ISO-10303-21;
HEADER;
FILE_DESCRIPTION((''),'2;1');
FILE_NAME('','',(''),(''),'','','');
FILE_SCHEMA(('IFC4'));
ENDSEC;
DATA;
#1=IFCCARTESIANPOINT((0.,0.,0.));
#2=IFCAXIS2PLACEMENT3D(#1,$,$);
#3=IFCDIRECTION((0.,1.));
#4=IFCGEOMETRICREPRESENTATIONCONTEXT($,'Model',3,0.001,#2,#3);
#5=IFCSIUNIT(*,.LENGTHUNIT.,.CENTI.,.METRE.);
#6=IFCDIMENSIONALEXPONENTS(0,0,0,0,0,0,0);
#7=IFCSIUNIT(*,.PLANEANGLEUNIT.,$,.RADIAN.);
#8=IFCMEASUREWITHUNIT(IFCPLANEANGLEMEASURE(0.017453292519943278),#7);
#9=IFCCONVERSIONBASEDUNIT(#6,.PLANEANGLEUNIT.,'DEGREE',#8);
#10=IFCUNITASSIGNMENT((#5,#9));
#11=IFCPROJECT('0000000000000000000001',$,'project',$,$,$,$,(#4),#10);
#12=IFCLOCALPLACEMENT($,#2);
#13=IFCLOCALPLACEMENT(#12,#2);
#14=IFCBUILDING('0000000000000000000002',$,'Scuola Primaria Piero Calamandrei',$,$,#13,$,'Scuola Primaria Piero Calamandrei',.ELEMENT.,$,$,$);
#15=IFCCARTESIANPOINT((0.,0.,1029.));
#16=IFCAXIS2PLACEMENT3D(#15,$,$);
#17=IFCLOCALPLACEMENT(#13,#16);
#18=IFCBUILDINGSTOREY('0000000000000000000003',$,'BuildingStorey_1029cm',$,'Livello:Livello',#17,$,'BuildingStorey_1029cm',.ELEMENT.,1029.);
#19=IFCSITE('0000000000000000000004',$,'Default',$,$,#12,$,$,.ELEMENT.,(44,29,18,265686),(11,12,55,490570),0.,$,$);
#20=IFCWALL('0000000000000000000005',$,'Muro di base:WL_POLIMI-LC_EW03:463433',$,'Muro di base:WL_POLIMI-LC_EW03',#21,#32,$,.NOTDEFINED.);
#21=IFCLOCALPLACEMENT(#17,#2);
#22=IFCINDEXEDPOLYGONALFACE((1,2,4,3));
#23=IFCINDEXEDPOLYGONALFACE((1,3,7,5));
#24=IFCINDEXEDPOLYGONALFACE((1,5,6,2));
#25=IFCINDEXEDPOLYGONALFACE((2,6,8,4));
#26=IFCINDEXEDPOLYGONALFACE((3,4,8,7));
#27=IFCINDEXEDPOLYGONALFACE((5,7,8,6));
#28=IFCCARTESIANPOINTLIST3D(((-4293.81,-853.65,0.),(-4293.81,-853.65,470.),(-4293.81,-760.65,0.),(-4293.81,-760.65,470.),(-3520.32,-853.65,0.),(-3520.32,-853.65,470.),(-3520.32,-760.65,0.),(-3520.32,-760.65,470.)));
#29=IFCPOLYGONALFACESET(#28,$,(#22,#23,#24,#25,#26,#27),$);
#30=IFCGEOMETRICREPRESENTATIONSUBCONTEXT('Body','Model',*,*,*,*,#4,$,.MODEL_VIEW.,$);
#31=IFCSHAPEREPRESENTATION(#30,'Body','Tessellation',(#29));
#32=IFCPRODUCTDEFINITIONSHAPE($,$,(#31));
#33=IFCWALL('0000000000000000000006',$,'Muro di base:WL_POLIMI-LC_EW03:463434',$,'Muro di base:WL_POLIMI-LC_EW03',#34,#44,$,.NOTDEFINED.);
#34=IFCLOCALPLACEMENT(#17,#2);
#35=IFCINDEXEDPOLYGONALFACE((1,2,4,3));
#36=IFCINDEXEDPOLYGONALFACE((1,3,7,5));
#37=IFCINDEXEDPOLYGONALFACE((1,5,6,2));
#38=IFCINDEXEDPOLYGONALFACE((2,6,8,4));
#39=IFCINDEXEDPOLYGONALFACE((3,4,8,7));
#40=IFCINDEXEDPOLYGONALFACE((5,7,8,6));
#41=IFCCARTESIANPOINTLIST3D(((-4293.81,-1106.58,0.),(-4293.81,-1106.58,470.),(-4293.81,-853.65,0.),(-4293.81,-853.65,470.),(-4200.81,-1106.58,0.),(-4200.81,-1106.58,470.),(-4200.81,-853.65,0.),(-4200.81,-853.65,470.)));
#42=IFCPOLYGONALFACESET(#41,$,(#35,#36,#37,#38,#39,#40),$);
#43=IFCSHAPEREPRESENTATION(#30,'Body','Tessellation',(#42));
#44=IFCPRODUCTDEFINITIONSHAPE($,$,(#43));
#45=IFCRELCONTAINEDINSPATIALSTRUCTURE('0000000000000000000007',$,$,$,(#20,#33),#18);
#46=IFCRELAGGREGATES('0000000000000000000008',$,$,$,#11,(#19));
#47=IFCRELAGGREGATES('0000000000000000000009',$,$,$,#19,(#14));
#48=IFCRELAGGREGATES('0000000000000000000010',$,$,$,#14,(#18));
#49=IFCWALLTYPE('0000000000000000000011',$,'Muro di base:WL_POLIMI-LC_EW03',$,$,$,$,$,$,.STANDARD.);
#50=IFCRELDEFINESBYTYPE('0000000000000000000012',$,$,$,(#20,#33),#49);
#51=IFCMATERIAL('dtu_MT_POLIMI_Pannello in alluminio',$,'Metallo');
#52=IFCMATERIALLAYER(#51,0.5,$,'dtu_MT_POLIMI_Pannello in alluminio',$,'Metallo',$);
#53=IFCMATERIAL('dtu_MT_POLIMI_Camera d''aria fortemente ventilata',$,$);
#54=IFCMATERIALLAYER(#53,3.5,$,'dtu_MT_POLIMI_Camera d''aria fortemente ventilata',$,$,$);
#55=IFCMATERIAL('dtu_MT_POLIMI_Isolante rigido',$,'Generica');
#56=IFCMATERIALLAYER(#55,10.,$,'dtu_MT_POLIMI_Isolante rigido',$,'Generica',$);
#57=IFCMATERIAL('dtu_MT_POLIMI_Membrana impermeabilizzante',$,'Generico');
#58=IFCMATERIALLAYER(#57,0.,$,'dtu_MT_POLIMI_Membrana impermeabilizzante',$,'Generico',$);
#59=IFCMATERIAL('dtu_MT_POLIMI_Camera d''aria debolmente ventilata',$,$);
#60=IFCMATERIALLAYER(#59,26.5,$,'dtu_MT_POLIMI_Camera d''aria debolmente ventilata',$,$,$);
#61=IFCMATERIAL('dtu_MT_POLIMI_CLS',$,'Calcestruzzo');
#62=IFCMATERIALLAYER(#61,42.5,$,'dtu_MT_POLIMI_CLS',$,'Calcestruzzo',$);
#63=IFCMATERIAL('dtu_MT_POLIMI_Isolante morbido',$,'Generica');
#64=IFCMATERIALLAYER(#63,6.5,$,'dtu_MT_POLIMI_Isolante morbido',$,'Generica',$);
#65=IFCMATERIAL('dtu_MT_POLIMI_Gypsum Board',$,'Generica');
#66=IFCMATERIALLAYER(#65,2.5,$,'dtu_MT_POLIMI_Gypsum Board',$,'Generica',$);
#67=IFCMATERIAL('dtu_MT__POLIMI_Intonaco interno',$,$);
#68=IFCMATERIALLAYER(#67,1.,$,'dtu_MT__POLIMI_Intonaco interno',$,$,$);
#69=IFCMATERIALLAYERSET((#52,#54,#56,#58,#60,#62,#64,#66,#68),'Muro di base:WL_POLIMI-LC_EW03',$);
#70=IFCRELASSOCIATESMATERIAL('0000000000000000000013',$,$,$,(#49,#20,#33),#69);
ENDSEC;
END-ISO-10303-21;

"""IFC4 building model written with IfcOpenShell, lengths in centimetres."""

from ifc_helpers import new_model, entity, si_unit, converted_unit, direction, frame, frame_2d, origin, place, context, subcontext, project, spatial, polyline, rectangle, extrude, clip, bounded_halfspace, material, layer, layer_set, layer_usage, type_object, element, save


model = new_model("IFC4")

# Units and contexts
model_context = context("Model", 3, precision=0.001, world=origin(), true_north=direction((0.0, 1.0)))
body_context = subcontext(model_context, "Body", "Model", "MODEL_VIEW")
ifc_project = project(units=[si_unit("LENGTHUNIT", "METRE", prefix="CENTI"), converted_unit("PLANEANGLEUNIT", "DEGREE", entity("IfcPlaneAngleMeasure", 0.017453292519943278), si_unit("PLANEANGLEUNIT", "RADIAN"), dimensions=[0, 0, 0, 0, 0, 0, 0])], contexts=[model_context])

# Site, building, storey
site_placement = place(None, origin())
site = spatial("IfcSite", under=ifc_project, at=site_placement, Name="Default", CompositionType="ELEMENT", RefLatitude=(44, 29, 18, 265686), RefLongitude=(11, 12, 55, 490570), RefElevation=0.0)
building_placement = place(site_placement, origin())
building = spatial("IfcBuilding", under=site, at=building_placement, Name="Scuola Primaria Piero Calamandrei", LongName="Scuola Primaria Piero Calamandrei", CompositionType="ELEMENT")
storey_placement = place(building_placement, frame((0.0, 0.0, 1029.0)))
storey = spatial("IfcBuildingStorey", under=building, at=storey_placement, Name="BuildingStorey_1029cm", ObjectType="Livello:Livello", LongName="BuildingStorey_1029cm", CompositionType="ELEMENT", Elevation=1029.0)

# Shared definitions
ifc_material_1 = material(Name="dtu_MT_POLIMI_Isolante rigido", Category="Generica")
ifc_material_2 = material(Name="dtu_MT__POLIMI_Intonaco interno")

# Shared definitions
ifc_material_3 = material(Name="dtu_MT_POLIMI_CLS", Category="Calcestruzzo")

# Shared definitions
ifc_material_4 = material(Name="dtu_MT_POLIMI_Pannello in alluminio", Category="Metallo")
ifc_layer_1 = layer(ifc_material_4, 0.5, Name="dtu_MT_POLIMI_Pannello in alluminio", Category="Metallo")
ifc_material_5 = material(Name="dtu_MT_POLIMI_Camera d'aria fortemente ventilata")
ifc_layer_2 = layer(ifc_material_5, 3.5, Name="dtu_MT_POLIMI_Camera d'aria fortemente ventilata")
ifc_layer_3 = layer(ifc_material_1, 10.0, Name="dtu_MT_POLIMI_Isolante rigido", Category="Generica")
ifc_material_6 = material(Name="dtu_MT_POLIMI_Membrana impermeabilizzante", Category="Generico")
ifc_layer_4 = layer(ifc_material_6, 0.0, Name="dtu_MT_POLIMI_Membrana impermeabilizzante", Category="Generico")
ifc_material_7 = material(Name="dtu_MT_POLIMI_Camera d'aria debolmente ventilata")
ifc_layer_5 = layer(ifc_material_7, 26.5, Name="dtu_MT_POLIMI_Camera d'aria debolmente ventilata")
ifc_layer_6 = layer(ifc_material_3, 42.5, Name="dtu_MT_POLIMI_CLS", Category="Calcestruzzo")
ifc_material_8 = material(Name="dtu_MT_POLIMI_Isolante morbido", Category="Generica")
ifc_layer_7 = layer(ifc_material_8, 6.5, Name="dtu_MT_POLIMI_Isolante morbido", Category="Generica")
ifc_material_9 = material(Name="dtu_MT_POLIMI_Gypsum Board", Category="Generica")
ifc_layer_8 = layer(ifc_material_9, 2.5, Name="dtu_MT_POLIMI_Gypsum Board", Category="Generica")
ifc_layer_9 = layer(ifc_material_2, 1.0, Name="dtu_MT__POLIMI_Intonaco interno")
ifc_layer_set_1 = layer_set([ifc_layer_1, ifc_layer_2, ifc_layer_3, ifc_layer_4, ifc_layer_5, ifc_layer_6, ifc_layer_7, ifc_layer_8, ifc_layer_9], Name="Muro di base:WL_POLIMI-LC_EW03")
wall_type = type_object("IfcWallType", Name="Muro di base:WL_POLIMI-LC_EW03", PredefinedType="STANDARD", material=ifc_layer_set_1)

# Walls
ifc_layer_usage_1 = layer_usage(ifc_layer_set_1, "AXIS2", "NEGATIVE", 46.5)
wall_1_placement = place(storey_placement, frame((-4293.81, -807.15, 0.0)))
element("IfcWall", 1, at=wall_1_placement, inside=storey, type_object=wall_type, material=ifc_layer_usage_1, Name="Muro di base:WL_POLIMI-LC_EW03:463433", ObjectType="Muro di base:WL_POLIMI-LC_EW03", PredefinedType="NOTDEFINED", context=body_context, shape_type="Clipping", body=[
    clip(extrude(rectangle(XDim=773.49, YDim=93.0, at=frame_2d((386.74, 0.0), x_axis=(-1.0, 0.0))), origin(), (0.0, 0.0, 1.0), 470.0), bounded_halfspace(frame((0.0, -46.5, 470.0)), False, frame((0.0, -46.5, 470.0)), polyline([(0.0, 0.0), (93.0, 0.0), (773.49, 0.0), (773.49, 93.0), (0.0, 93.0), (0.0, 0.0)]))),
])
ifc_layer_usage_2 = layer_usage(ifc_layer_set_1, "AXIS2", "NEGATIVE", 46.5)
wall_2_placement = place(storey_placement, frame((-4247.31, -1106.58, 0.0), z_axis=(0.0, 0.0, 1.0), x_axis=(0.0, 1.0, 0.0)))
element("IfcWall", 2, at=wall_2_placement, inside=storey, type_object=wall_type, material=ifc_layer_usage_2, Name="Muro di base:WL_POLIMI-LC_EW03:463434", ObjectType="Muro di base:WL_POLIMI-LC_EW03", PredefinedType="NOTDEFINED", context=body_context, shape_type="SweptSolid", body=[
    extrude(rectangle(XDim=93.0, YDim=252.92, at=frame_2d((0.0, 0.0), x_axis=(1.0, 0.0))), frame((126.46, 0.0, 0.0), z_axis=(0.0, 0.0, 1.0), x_axis=(0.0, 1.0, 0.0)), (0.0, 0.0, 1.0), 470.0),
])

save(model, "model.ifc")
